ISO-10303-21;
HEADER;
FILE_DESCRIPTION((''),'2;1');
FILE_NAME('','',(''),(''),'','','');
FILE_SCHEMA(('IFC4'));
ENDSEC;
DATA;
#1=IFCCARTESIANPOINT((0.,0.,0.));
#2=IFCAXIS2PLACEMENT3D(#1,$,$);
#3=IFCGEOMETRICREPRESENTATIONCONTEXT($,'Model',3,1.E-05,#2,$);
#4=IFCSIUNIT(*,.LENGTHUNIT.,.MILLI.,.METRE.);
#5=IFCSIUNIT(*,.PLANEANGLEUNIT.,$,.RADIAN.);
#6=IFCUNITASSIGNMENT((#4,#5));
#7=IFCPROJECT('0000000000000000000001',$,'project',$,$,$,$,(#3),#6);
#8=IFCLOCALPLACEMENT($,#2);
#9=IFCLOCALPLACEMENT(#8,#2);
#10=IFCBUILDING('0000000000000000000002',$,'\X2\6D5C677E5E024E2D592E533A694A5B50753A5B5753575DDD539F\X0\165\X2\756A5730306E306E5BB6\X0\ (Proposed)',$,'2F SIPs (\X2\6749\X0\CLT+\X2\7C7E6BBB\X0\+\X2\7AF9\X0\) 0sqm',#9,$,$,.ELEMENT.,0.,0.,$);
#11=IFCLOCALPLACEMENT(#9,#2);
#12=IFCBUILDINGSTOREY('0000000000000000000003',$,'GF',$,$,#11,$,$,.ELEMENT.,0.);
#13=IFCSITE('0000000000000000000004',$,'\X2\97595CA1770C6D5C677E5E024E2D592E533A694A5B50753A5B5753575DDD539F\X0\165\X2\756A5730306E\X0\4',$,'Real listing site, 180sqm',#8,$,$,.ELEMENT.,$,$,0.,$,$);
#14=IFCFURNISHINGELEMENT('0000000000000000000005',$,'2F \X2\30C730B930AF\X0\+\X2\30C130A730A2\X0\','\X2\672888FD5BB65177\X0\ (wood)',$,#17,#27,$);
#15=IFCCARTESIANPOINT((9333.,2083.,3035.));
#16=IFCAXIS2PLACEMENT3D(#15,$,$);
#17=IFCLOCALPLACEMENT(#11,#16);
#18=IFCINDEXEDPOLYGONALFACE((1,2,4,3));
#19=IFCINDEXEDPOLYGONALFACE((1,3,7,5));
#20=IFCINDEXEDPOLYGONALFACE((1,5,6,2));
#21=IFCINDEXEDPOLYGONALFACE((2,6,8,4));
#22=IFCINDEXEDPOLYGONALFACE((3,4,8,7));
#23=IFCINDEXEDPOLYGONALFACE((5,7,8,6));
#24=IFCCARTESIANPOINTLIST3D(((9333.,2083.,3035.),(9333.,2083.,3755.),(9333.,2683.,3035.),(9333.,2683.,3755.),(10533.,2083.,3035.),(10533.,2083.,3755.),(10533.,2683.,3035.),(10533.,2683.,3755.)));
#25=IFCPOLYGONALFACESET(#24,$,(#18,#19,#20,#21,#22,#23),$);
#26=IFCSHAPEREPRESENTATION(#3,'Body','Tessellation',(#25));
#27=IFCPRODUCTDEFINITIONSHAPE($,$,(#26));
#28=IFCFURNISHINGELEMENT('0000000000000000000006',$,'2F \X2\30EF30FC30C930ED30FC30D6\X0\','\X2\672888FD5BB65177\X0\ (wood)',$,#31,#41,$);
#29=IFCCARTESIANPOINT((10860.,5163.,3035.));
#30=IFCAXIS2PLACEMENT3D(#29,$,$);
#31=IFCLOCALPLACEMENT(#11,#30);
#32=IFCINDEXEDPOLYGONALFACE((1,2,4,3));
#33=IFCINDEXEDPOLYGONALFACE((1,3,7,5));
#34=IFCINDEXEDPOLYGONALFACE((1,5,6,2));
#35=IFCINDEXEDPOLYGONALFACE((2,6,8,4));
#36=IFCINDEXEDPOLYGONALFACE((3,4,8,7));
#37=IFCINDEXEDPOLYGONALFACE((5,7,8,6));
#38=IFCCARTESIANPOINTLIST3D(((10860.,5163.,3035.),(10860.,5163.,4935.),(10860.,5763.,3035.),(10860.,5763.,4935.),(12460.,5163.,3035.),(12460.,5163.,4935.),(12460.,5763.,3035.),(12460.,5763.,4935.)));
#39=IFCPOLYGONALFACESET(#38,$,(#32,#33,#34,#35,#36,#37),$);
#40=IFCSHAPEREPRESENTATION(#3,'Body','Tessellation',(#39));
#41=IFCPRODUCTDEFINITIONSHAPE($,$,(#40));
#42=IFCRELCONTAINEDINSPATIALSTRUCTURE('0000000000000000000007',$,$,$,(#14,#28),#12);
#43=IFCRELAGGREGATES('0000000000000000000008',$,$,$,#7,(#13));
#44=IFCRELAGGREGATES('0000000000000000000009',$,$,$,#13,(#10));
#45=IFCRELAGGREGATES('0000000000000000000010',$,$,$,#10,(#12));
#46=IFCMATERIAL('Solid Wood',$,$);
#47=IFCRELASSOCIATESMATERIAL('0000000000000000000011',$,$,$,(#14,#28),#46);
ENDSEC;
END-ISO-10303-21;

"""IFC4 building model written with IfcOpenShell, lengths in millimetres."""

from ifc_helpers import new_model, si_unit, frame, frame_2d, origin, place, context, project, spatial, rectangle, extrude, material, element, save


model = new_model("IFC4")

# Units and contexts
model_context = context("Model", 3, precision=1e-05, world=origin())
ifc_project = project(units=[si_unit("LENGTHUNIT", "METRE", prefix="MILLI"), si_unit("PLANEANGLEUNIT", "RADIAN")], contexts=[model_context])

# Site, building, storey
site_placement = place(None, origin())
site = spatial("IfcSite", under=ifc_project, at=site_placement, Name="静岡県浜松市中央区楊子町字南川原165番地の4", ObjectType="Real listing site, 180sqm", CompositionType="ELEMENT", RefElevation=0.0)
building_placement = place(site_placement, origin())
building = spatial("IfcBuilding", under=site, at=building_placement, Name="浜松市中央区楊子町字南川原165番地のの家 (Proposed)", ObjectType="2F SIPs (杉CLT+籾殻+竹) 0sqm", CompositionType="ELEMENT", ElevationOfRefHeight=0.0, ElevationOfTerrain=0.0)
storey_placement = place(building_placement, origin())
storey = spatial("IfcBuildingStorey", under=building, at=storey_placement, Name="GF", CompositionType="ELEMENT", Elevation=0.0)

# Shared definitions
ifc_material_1 = material(Name="Solid Wood")

# Furnishing elements
furnishing_1_placement = place(storey_placement, frame((9333.0, 2083.0, 3035.0)))
element("IfcFurnishingElement", 1, at=furnishing_1_placement, inside=storey, material=ifc_material_1, Name="2F デスク+チェア", Description="木製家具 (wood)", context=model_context, shape_type="SweptSolid", body=[
    extrude(rectangle(XDim=1200.0, YDim=600.0, at=frame_2d((600.0, 300.0))), frame((9333.0, 2083.0, 3035.0)), (0.0, 0.0, 1.0), 720.0),
])
furnishing_2_placement = place(storey_placement, frame((10860.0, 5163.0, 3035.0)))
element("IfcFurnishingElement", 2, at=furnishing_2_placement, inside=storey, material=ifc_material_1, Name="2F ワードローブ", Description="木製家具 (wood)", context=model_context, shape_type="SweptSolid", body=[
    extrude(rectangle(XDim=1600.0, YDim=600.0, at=frame_2d((800.0, 300.0))), frame((10860.0, 5163.0, 3035.0)), (0.0, 0.0, 1.0), 1900.0),
])

save(model, "model.ifc")
